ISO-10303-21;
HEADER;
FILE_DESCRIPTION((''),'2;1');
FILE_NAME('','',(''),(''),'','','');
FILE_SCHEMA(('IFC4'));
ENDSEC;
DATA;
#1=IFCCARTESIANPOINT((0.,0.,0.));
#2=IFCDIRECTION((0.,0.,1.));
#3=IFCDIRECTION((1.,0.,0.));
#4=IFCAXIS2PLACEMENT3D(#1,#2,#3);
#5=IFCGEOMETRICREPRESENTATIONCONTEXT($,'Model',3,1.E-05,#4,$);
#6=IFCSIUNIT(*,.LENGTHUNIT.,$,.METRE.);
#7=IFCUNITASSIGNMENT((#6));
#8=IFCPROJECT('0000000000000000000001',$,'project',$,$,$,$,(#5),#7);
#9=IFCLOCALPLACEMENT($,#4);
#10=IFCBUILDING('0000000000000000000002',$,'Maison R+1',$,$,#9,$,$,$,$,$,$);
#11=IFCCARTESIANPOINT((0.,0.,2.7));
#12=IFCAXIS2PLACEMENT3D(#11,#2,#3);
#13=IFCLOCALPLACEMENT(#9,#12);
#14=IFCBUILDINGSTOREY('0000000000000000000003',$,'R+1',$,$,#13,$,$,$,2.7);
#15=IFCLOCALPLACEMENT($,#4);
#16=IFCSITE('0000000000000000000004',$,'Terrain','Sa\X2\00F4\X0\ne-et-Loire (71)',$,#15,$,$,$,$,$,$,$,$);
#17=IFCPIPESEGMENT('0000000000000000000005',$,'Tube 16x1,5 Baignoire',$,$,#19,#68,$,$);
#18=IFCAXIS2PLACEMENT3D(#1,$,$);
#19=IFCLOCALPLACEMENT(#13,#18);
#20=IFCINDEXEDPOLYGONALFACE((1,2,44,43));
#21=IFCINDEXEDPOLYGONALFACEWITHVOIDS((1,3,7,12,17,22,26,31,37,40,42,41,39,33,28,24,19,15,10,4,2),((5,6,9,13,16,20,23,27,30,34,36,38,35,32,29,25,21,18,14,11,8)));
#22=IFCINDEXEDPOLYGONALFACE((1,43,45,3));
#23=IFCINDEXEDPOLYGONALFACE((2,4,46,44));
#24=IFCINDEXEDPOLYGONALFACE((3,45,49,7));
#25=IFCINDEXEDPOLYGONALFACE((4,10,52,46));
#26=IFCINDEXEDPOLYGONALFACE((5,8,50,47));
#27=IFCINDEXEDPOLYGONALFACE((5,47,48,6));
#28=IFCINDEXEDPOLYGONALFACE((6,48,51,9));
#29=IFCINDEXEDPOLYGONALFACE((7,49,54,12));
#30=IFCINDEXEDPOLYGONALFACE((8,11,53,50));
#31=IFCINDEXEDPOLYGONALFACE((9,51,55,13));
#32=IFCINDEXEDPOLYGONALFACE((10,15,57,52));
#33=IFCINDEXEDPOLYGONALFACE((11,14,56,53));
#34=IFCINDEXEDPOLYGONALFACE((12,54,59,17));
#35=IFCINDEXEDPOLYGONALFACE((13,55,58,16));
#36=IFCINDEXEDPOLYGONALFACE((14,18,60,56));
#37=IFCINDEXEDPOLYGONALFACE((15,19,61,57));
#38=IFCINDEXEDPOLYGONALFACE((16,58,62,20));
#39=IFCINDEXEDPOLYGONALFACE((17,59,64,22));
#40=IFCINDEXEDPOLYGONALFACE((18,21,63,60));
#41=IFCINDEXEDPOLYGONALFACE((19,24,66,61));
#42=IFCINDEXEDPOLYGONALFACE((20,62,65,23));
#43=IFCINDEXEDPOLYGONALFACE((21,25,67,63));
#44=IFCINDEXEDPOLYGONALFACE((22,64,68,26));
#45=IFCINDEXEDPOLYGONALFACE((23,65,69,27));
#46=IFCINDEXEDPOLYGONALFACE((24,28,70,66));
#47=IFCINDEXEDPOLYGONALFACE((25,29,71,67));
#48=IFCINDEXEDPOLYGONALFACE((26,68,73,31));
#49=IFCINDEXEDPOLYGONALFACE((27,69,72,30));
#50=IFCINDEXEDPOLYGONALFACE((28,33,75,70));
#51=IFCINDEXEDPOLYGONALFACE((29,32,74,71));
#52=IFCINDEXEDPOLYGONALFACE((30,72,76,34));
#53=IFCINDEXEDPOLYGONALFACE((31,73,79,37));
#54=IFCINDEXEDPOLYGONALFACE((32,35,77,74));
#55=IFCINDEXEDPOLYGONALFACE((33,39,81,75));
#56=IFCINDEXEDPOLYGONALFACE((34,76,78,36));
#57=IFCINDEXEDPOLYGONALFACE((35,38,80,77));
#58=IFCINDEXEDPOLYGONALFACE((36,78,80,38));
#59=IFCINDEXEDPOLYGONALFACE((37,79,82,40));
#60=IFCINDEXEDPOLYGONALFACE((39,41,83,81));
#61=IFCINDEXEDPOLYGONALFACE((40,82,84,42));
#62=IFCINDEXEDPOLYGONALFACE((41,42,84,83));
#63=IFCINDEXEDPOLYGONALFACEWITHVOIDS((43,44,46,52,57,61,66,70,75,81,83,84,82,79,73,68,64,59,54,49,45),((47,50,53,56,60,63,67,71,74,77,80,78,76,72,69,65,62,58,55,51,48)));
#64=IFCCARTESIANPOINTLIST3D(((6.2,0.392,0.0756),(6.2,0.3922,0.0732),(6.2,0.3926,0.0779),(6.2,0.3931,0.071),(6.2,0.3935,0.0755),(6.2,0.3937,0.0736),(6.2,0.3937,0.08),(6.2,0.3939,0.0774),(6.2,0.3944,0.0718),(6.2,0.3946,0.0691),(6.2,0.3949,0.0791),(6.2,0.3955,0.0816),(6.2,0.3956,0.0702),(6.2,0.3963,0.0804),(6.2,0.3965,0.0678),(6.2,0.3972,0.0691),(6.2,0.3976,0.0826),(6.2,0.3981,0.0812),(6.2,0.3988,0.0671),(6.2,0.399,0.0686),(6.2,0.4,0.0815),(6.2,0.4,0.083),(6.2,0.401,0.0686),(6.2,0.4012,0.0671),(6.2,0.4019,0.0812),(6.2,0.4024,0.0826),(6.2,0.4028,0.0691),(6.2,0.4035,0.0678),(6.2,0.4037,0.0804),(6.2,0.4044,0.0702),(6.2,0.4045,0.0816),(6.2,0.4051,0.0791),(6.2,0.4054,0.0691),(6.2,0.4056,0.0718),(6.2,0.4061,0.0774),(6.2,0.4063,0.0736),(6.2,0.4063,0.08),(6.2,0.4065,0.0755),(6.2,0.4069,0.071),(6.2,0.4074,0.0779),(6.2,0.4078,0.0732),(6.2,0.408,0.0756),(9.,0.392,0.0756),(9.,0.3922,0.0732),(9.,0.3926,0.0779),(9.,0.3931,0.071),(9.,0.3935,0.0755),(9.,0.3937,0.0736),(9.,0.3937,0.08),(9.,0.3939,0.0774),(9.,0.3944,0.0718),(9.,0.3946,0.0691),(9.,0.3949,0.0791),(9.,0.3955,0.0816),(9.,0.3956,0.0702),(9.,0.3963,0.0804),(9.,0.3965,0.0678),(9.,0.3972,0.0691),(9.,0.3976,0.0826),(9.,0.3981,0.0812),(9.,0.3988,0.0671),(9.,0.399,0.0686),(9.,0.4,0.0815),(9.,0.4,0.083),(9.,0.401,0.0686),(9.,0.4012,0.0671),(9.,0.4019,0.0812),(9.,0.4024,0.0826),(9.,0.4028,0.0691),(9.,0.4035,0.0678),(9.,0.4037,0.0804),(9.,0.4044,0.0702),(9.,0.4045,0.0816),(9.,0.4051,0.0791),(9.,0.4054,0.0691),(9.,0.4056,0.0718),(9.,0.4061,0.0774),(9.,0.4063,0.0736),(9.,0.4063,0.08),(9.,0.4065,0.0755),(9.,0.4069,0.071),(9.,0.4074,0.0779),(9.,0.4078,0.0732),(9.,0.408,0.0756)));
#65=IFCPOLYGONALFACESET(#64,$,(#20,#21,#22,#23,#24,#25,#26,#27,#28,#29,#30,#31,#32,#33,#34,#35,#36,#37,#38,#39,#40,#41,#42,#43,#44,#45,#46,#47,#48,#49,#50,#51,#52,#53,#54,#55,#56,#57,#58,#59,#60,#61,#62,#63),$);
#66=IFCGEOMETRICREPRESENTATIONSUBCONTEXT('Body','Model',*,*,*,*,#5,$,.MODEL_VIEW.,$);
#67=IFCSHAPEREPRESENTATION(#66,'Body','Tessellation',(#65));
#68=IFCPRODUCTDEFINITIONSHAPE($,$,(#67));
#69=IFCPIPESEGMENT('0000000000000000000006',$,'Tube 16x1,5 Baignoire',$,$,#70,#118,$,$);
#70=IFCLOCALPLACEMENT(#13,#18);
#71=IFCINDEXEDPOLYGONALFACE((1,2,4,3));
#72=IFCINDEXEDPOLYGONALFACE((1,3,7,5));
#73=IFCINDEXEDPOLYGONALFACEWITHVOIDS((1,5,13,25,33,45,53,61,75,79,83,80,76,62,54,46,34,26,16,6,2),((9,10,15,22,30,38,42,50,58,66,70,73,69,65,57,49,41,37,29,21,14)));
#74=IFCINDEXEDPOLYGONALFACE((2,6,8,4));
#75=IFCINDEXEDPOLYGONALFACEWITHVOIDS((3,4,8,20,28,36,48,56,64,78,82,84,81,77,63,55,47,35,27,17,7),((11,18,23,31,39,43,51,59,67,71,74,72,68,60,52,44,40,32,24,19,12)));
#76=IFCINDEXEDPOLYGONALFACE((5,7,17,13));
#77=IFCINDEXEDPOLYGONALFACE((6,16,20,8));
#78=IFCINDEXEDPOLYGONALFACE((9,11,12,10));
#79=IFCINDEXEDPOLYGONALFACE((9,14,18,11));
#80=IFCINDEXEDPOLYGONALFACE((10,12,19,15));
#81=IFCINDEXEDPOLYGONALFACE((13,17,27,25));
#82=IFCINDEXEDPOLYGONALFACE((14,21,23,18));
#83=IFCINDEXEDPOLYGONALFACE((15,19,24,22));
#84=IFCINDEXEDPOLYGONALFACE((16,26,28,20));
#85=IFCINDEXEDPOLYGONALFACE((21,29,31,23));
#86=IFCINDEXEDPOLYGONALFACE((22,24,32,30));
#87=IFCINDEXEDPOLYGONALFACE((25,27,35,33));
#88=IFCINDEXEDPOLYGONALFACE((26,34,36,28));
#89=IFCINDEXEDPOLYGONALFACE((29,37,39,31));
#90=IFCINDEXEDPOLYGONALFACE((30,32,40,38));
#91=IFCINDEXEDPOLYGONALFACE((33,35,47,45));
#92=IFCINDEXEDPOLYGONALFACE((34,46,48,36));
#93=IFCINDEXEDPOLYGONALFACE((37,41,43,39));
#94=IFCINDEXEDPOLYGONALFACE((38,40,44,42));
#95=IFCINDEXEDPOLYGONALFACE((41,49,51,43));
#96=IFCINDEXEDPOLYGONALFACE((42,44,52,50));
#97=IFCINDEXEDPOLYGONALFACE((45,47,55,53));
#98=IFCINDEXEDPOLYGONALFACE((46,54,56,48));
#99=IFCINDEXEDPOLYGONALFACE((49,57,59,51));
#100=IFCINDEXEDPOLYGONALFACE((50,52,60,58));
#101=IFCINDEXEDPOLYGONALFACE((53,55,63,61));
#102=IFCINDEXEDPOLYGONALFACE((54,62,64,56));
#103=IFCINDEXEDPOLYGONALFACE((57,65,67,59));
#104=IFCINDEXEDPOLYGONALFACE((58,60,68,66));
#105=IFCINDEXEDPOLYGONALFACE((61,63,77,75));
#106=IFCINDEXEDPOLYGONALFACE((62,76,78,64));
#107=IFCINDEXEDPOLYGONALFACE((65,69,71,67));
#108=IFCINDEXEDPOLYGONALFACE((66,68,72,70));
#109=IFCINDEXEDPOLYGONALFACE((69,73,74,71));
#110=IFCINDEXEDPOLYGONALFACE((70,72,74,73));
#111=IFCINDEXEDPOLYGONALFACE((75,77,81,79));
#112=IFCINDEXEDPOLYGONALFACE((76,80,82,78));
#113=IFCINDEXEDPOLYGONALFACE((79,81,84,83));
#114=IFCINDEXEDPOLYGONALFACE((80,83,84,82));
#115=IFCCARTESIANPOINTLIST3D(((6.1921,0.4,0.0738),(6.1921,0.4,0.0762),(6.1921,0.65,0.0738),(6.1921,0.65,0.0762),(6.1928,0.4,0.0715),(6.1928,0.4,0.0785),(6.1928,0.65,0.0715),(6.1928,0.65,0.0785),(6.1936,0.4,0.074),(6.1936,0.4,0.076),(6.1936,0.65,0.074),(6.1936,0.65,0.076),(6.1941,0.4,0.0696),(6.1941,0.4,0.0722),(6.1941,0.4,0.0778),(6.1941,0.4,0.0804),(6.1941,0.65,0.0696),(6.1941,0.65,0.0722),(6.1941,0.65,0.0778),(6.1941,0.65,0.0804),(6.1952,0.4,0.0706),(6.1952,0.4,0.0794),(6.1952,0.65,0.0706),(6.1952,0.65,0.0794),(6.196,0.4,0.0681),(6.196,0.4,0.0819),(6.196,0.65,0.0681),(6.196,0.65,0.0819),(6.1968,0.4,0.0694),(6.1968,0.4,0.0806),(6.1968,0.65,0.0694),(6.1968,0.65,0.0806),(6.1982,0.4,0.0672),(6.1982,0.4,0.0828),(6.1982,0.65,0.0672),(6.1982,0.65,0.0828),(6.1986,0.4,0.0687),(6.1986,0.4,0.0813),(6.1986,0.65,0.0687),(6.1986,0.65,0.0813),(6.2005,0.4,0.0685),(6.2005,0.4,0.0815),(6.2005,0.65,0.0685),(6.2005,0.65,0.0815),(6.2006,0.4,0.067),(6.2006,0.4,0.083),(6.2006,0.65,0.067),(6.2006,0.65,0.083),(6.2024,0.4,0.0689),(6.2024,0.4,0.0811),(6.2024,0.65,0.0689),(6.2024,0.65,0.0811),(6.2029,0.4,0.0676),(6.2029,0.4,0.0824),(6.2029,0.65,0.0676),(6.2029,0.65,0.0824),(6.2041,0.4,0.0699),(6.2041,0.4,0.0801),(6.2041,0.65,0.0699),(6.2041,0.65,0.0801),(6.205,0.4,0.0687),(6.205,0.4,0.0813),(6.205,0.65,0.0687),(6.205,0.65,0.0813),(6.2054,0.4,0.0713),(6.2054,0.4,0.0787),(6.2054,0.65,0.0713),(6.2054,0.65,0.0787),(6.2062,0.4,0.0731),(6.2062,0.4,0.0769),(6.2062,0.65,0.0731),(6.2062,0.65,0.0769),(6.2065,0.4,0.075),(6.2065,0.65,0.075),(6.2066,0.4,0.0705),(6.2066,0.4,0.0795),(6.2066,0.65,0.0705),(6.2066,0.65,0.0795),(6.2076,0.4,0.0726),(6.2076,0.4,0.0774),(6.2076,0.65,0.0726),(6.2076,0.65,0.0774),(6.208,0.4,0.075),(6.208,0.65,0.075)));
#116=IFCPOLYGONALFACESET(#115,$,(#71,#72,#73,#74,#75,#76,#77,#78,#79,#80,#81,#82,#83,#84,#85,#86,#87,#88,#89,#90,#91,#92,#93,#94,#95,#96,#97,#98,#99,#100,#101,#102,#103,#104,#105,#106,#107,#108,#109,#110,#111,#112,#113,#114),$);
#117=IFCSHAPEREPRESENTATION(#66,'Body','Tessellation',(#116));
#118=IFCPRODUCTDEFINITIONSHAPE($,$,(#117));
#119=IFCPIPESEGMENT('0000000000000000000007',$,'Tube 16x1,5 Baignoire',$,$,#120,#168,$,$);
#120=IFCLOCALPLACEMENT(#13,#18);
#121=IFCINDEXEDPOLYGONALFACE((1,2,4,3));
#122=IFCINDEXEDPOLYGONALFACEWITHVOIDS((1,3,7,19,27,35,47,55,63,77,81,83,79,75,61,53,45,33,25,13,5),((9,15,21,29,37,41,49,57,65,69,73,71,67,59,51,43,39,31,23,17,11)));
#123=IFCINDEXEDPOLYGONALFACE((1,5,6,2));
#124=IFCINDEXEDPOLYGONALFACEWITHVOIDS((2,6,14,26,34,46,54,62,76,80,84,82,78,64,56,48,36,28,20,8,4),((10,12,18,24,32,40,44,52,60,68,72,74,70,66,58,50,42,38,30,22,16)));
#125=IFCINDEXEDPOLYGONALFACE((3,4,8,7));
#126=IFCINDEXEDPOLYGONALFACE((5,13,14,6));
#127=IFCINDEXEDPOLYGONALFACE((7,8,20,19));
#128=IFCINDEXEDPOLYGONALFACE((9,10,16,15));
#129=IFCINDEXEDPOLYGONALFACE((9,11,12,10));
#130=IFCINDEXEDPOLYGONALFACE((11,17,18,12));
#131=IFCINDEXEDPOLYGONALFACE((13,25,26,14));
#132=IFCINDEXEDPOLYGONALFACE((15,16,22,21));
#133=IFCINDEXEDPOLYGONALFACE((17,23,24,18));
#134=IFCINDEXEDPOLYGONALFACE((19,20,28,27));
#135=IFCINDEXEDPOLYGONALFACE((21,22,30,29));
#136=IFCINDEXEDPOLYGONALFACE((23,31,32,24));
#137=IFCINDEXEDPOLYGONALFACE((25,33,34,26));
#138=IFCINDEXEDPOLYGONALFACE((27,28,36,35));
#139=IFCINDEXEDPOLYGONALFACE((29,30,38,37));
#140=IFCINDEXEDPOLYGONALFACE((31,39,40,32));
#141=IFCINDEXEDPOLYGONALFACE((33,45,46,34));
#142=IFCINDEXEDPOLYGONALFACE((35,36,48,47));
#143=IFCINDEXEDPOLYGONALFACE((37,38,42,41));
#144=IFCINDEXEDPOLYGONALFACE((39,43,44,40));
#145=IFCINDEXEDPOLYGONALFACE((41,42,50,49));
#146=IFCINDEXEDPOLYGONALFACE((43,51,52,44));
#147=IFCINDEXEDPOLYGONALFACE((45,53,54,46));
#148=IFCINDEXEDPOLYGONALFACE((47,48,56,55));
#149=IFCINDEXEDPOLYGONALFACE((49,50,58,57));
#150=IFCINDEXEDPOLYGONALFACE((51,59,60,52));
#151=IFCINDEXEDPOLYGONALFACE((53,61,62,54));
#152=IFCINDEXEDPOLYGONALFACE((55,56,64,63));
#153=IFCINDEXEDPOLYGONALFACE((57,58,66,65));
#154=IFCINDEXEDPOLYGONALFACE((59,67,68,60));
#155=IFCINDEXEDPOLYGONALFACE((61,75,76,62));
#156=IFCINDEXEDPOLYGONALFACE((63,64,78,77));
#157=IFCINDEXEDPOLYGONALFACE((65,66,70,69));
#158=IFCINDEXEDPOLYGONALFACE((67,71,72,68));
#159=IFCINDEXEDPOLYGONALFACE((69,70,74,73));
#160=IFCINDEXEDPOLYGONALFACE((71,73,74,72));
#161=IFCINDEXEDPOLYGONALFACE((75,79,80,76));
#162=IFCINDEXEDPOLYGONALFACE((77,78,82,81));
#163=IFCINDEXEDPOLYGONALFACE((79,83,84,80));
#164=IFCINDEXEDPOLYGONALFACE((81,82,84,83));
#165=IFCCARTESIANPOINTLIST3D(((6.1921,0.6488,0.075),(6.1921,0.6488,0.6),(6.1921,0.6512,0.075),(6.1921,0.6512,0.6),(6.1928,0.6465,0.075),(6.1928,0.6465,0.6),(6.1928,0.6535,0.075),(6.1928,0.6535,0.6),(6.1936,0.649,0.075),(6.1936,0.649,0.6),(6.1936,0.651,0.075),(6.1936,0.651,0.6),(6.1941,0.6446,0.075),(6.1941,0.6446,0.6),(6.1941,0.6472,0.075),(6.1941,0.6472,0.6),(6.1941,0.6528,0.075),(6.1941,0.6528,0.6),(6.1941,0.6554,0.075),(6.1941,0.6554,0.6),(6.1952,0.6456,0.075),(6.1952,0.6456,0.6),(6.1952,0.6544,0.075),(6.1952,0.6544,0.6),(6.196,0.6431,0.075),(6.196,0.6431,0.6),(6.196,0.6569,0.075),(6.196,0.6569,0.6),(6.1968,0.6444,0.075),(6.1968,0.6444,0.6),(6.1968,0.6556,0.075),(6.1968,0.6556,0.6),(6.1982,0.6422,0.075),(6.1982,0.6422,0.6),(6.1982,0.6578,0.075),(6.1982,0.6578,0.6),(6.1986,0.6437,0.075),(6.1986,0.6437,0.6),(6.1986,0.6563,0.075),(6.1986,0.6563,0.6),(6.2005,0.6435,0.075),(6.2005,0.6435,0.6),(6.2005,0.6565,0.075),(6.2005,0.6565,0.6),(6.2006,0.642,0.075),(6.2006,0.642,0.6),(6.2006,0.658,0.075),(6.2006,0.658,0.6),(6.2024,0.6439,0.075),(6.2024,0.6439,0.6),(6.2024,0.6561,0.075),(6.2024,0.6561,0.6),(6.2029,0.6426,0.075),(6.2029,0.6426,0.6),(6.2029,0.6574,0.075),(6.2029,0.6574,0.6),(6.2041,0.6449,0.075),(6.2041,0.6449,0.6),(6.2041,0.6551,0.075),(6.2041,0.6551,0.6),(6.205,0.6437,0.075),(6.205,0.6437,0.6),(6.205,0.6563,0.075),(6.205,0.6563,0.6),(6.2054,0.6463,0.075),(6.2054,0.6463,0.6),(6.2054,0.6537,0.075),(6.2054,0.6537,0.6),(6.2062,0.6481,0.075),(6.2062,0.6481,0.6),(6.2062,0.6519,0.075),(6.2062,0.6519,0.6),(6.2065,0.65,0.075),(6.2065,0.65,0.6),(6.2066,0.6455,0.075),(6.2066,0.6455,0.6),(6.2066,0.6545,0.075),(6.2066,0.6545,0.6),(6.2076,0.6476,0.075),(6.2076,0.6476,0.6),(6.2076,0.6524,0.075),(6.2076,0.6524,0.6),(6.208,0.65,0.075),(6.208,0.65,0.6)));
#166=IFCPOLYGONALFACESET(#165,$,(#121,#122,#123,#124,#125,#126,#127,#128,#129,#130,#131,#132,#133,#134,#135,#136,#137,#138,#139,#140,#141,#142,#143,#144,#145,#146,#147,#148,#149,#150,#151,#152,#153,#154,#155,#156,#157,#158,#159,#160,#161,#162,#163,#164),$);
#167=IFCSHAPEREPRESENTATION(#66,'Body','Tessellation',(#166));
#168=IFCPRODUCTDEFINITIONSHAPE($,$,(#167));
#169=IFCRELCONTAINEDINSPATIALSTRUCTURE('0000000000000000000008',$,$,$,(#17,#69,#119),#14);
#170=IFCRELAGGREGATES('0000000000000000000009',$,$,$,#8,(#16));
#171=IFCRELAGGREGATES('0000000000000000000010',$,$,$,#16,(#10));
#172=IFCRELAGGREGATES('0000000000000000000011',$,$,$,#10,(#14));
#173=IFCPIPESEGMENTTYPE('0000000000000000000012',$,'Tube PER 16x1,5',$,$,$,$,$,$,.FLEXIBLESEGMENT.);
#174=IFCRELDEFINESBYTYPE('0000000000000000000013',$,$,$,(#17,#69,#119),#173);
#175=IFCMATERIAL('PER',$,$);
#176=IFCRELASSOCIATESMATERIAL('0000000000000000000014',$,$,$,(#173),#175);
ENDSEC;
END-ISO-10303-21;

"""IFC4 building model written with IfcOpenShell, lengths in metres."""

from ifc_helpers import new_model, si_unit, frame, origin_with_axes, place, context, subcontext, project, spatial, hollow_circle, extrude, material, type_object, element, save


model = new_model("IFC4")

# Units and contexts
model_context = context("Model", 3, precision=1e-05, world=origin_with_axes())
body_context = subcontext(model_context, "Body", "Model", "MODEL_VIEW")
ifc_project = project(units=[si_unit("LENGTHUNIT", "METRE")], contexts=[model_context])

# Site, building, storey
site_placement = place(None, origin_with_axes())
site = spatial("IfcSite", under=ifc_project, at=site_placement, Name="Terrain", Description="Saône-et-Loire (71)")
building_placement = place(None, origin_with_axes())
building = spatial("IfcBuilding", under=site, at=building_placement, Name="Maison R+1")
storey_placement = place(building_placement, frame((0.0, 0.0, 2.7), z_axis=(0.0, 0.0, 1.0), x_axis=(1.0, 0.0, 0.0)))
storey = spatial("IfcBuildingStorey", under=building, at=storey_placement, Name="R+1", Elevation=2.7)

# Pipe segments
ifc_material_1 = material(Name="PER")
pipe_segment_type_1 = type_object("IfcPipeSegmentType", Name="Tube PER 16x1,5", PredefinedType="FLEXIBLESEGMENT", material=ifc_material_1)
pipe_segment_1_placement = place(storey_placement, frame((9.0, 0.4, 0.075), z_axis=(-1.0, 0.0, 0.0), x_axis=(0.0, 0.0, 1.0)))
element("IfcPipeSegment", 1, at=pipe_segment_1_placement, inside=storey, type_object=pipe_segment_type_1, Name="Tube 16x1,5 Baignoire", context=body_context, shape_type="SweptSolid", body=[
    extrude(hollow_circle(Radius=0.008, WallThickness=0.0015), origin_with_axes(), (0.0, 0.0, 1.0), 2.8),
])
pipe_segment_2_placement = place(storey_placement, frame((6.2, 0.4, 0.075), z_axis=(0.0, 1.0, 0.0), x_axis=(1.0, 0.0, 0.0)))
element("IfcPipeSegment", 2, at=pipe_segment_2_placement, inside=storey, type_object=pipe_segment_type_1, Name="Tube 16x1,5 Baignoire", context=body_context, shape_type="SweptSolid", body=[
    extrude(hollow_circle(Radius=0.008, WallThickness=0.0015), origin_with_axes(), (0.0, 0.0, 1.0), 0.25),
])
pipe_segment_3_placement = place(storey_placement, frame((6.2, 0.65, 0.075), z_axis=(0.0, 0.0, 1.0), x_axis=(1.0, 0.0, 0.0)))
element("IfcPipeSegment", 3, at=pipe_segment_3_placement, inside=storey, type_object=pipe_segment_type_1, Name="Tube 16x1,5 Baignoire", context=body_context, shape_type="SweptSolid", body=[
    extrude(hollow_circle(Radius=0.008, WallThickness=0.0015), origin_with_axes(), (0.0, 0.0, 1.0), 0.525),
])

save(model, "model.ifc")
